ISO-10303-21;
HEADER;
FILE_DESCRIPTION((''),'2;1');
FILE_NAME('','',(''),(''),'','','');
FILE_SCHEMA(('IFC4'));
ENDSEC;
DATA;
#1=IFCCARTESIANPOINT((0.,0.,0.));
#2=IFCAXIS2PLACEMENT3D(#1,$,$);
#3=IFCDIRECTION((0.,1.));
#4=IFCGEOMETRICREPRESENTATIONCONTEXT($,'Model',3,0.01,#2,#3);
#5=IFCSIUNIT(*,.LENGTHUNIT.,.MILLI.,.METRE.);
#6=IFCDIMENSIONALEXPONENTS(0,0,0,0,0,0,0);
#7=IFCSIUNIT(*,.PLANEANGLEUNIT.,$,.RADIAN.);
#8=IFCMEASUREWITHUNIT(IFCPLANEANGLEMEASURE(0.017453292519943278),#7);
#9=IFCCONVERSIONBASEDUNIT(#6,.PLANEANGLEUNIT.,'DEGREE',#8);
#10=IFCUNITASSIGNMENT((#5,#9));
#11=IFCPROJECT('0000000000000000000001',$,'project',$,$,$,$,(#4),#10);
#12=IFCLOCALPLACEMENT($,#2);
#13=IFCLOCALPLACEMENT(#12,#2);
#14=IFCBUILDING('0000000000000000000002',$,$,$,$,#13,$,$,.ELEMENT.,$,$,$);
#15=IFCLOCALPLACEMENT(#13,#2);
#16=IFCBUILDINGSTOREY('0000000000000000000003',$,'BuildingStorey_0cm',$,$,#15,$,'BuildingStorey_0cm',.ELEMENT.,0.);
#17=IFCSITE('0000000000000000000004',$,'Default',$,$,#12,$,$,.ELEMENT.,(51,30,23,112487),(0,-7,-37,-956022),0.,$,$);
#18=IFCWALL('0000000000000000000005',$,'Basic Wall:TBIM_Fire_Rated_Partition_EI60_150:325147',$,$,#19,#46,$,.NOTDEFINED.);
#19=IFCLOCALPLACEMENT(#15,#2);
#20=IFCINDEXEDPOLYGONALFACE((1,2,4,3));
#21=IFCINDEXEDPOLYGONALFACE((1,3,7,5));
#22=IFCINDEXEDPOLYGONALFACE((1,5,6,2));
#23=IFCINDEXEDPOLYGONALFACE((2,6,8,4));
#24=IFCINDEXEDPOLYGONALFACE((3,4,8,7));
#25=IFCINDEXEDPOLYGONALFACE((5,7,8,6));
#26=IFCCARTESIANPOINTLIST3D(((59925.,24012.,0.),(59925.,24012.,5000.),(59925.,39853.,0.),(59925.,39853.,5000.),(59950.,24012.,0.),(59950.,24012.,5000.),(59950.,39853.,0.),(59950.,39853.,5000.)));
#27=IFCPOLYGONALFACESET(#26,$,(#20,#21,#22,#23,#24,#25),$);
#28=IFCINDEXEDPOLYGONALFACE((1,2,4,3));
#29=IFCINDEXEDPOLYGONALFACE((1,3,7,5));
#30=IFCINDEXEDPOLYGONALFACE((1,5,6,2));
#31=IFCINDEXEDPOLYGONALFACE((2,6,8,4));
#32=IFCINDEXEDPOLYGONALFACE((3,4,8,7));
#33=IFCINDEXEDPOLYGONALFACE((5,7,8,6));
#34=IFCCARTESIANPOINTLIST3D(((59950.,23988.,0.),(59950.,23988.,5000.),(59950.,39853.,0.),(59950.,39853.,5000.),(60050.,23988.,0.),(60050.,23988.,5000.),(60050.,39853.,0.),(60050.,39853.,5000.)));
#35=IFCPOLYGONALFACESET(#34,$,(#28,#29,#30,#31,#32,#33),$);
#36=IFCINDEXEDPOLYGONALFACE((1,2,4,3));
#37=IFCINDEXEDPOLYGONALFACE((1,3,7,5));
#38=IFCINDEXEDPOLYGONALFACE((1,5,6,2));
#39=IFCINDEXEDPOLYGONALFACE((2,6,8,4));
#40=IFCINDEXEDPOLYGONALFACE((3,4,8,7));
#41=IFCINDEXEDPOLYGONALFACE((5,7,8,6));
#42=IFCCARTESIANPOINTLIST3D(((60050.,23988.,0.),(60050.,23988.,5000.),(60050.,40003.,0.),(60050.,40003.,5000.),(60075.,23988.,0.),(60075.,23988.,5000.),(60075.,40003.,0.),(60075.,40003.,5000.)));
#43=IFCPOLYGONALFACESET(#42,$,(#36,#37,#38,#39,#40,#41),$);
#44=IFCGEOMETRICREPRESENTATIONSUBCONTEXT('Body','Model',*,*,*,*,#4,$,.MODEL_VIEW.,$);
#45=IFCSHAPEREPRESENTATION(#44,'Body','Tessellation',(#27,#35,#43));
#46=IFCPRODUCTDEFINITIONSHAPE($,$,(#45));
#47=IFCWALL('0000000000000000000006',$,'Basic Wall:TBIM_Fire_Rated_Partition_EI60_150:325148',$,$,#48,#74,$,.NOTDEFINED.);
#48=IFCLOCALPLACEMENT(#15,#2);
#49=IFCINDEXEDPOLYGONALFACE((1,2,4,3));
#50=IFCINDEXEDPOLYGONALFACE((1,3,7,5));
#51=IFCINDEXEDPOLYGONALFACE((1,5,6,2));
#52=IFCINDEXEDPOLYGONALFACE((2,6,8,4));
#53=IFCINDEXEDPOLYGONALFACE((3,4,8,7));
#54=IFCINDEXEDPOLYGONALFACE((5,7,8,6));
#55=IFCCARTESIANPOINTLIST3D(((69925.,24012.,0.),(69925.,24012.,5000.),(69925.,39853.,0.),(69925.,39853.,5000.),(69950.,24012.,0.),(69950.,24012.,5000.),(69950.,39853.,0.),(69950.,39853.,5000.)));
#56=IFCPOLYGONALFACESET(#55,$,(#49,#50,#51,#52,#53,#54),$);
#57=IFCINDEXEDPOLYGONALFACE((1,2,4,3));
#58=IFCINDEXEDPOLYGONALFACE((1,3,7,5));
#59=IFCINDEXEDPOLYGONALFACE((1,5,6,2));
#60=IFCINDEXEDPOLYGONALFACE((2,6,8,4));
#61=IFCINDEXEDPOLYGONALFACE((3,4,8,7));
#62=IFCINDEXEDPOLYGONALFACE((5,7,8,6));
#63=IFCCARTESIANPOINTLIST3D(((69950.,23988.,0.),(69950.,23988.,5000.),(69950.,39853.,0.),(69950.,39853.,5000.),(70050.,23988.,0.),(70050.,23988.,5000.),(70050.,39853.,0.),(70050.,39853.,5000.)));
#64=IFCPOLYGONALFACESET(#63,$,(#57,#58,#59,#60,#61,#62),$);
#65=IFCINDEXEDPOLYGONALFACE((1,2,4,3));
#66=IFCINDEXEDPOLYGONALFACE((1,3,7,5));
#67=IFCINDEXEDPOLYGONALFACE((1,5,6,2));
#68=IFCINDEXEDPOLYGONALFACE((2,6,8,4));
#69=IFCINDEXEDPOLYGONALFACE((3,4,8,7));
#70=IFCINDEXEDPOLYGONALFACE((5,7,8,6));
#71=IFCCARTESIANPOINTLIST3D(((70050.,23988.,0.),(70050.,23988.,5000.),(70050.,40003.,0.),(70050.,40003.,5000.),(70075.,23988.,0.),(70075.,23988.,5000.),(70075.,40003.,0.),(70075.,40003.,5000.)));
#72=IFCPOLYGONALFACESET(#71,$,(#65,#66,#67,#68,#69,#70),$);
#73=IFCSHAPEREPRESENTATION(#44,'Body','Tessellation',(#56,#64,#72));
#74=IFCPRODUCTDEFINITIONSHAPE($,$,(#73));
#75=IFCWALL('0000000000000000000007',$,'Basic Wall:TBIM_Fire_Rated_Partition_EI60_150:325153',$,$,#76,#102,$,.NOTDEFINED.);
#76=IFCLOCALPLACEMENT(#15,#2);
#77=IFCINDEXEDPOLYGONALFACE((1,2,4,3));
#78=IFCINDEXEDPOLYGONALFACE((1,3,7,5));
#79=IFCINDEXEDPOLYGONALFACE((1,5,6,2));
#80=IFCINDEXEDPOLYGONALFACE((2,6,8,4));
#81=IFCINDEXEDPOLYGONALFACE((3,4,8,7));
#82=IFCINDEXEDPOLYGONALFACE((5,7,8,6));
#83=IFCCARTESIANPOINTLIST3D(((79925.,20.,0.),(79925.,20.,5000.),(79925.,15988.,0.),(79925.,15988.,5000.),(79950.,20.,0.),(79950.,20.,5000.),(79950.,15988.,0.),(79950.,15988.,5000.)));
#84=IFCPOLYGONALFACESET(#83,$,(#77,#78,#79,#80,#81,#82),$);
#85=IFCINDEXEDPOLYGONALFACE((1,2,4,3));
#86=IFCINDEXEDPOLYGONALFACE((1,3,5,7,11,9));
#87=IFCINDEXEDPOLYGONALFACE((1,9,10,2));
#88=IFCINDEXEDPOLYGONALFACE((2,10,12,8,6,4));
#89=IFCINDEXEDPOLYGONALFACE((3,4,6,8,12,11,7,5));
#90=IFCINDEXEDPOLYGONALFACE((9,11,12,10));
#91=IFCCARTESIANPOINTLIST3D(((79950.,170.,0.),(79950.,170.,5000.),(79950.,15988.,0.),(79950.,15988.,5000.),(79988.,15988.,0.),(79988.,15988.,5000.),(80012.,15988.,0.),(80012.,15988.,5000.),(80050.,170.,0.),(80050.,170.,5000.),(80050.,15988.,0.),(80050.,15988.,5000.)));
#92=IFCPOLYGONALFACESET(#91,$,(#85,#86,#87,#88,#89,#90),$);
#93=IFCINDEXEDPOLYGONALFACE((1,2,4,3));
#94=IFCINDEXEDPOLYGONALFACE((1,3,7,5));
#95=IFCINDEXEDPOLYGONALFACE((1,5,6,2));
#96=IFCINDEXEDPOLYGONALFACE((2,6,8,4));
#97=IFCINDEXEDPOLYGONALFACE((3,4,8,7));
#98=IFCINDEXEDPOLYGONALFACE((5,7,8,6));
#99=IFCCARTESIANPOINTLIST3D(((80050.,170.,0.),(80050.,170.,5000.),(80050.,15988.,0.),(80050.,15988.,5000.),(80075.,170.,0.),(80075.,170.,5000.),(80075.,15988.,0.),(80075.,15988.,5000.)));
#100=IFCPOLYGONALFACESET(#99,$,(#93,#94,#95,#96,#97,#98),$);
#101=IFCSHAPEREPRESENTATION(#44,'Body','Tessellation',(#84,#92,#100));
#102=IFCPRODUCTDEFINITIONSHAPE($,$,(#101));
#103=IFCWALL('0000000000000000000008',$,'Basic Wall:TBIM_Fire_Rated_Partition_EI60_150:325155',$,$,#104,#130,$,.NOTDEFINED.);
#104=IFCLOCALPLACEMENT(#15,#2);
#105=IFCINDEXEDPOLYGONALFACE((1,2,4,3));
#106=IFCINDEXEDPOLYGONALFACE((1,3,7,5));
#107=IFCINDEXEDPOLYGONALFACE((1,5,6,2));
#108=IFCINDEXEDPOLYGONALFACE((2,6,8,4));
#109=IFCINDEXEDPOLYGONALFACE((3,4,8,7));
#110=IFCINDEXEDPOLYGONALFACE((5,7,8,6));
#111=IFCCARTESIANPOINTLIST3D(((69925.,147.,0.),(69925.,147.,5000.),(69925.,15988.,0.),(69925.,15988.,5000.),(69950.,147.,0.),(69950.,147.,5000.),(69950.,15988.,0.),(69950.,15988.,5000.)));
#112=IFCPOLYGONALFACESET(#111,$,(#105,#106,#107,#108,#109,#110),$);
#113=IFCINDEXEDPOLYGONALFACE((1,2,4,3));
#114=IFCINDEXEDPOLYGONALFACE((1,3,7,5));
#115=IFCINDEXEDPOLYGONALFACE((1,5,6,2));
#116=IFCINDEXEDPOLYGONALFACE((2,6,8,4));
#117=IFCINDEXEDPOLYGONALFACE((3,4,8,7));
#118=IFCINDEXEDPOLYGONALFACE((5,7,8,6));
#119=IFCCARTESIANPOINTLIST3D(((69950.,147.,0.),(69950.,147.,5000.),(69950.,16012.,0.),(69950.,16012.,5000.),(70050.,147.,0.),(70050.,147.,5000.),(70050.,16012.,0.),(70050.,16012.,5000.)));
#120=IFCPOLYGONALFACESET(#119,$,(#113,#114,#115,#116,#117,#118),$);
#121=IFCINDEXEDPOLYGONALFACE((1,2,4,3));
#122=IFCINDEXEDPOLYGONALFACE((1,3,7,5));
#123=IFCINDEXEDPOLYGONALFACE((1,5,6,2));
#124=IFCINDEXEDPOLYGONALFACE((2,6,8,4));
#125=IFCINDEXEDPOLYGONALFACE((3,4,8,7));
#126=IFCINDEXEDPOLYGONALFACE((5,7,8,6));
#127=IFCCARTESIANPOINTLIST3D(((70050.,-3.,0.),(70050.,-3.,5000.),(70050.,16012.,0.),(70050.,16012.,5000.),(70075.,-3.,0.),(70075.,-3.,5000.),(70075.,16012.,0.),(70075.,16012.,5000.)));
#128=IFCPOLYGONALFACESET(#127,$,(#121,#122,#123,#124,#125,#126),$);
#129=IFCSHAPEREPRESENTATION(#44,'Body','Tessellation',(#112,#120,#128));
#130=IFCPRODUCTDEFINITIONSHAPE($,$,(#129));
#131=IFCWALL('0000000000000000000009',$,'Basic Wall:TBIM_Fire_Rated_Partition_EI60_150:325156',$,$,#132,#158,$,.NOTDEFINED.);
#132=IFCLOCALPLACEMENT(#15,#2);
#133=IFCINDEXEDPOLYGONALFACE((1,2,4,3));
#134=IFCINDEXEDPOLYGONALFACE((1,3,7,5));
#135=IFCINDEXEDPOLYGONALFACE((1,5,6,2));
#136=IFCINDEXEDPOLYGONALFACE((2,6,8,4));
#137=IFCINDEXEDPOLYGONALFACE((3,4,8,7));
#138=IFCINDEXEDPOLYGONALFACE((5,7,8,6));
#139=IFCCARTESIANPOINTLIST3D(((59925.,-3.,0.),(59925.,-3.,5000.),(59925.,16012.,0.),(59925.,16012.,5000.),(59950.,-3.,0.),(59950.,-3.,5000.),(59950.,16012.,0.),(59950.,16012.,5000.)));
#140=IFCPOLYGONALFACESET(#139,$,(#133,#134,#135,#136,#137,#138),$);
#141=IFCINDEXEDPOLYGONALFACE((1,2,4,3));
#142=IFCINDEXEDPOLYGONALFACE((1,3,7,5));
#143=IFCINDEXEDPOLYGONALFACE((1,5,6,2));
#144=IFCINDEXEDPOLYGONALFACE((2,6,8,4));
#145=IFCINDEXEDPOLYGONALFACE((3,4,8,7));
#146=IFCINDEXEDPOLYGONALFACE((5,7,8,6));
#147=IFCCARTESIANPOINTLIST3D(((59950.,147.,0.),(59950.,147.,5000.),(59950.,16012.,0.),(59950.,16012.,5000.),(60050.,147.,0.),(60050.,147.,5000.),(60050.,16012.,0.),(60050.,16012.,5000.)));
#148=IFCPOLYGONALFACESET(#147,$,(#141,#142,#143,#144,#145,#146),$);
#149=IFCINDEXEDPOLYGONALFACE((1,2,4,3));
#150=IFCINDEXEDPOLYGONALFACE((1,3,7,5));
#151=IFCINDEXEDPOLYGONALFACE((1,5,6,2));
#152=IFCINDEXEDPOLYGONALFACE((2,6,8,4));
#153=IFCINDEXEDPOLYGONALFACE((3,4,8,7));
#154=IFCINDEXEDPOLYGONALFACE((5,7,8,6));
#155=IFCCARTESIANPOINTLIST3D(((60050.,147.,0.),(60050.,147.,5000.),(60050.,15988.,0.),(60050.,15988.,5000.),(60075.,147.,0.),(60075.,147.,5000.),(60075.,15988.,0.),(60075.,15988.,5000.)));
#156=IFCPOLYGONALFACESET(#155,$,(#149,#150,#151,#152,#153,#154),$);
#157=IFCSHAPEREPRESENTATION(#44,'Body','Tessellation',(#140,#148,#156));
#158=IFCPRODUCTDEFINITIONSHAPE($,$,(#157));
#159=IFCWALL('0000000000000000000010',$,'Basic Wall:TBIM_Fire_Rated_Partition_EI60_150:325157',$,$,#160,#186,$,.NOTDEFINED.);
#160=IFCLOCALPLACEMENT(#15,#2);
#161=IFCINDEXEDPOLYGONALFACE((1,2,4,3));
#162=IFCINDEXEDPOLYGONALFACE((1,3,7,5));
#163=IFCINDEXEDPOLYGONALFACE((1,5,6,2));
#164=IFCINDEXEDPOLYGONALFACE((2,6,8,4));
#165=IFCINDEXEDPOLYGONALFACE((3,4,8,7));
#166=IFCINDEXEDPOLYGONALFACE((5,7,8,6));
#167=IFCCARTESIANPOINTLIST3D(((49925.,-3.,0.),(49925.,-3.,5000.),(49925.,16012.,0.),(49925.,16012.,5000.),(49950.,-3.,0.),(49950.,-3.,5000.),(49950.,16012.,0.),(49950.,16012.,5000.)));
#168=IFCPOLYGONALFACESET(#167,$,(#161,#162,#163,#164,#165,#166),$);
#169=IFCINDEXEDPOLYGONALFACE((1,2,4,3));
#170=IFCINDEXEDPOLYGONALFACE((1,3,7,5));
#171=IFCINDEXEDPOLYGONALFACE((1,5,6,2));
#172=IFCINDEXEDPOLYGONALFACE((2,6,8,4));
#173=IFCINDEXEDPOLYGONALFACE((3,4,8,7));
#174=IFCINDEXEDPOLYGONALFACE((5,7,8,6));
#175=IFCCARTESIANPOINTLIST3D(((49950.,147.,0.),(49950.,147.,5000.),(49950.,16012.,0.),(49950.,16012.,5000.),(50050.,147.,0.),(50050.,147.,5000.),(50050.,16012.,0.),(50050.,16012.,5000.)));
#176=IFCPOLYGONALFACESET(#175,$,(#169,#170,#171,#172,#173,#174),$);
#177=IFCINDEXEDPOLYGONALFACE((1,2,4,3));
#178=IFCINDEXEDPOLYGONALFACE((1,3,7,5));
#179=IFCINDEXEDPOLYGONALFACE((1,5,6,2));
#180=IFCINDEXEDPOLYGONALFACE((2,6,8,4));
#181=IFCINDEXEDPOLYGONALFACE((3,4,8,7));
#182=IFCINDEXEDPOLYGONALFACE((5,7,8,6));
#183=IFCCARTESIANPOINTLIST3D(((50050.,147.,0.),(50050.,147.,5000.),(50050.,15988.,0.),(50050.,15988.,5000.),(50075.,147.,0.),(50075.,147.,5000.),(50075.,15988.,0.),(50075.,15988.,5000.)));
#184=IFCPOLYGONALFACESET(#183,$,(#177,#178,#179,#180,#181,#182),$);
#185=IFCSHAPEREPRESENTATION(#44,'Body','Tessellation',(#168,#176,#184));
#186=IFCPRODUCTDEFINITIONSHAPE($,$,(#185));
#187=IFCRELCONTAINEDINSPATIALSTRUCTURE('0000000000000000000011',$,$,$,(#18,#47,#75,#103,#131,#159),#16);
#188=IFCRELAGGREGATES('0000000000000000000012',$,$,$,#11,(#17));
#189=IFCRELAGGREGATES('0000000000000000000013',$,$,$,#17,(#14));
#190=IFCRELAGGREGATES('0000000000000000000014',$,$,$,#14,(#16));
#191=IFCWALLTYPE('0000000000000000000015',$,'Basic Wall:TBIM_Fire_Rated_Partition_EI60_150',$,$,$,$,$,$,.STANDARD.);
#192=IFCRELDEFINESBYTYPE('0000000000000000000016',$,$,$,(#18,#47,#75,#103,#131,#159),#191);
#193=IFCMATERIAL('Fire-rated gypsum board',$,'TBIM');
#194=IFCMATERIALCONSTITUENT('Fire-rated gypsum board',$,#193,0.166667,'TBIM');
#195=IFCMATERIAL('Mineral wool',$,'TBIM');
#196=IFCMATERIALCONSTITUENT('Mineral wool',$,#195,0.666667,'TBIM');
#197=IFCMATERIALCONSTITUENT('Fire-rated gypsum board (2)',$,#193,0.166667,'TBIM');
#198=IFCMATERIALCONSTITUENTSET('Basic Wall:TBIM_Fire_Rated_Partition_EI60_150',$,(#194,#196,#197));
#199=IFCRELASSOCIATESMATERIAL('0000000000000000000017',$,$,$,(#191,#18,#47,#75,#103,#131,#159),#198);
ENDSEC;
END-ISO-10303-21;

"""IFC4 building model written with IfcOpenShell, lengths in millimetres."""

from ifc_helpers import new_model, entity, si_unit, converted_unit, direction, frame, origin, place, context, subcontext, project, spatial, indexed_curve, outline, extrude, material, constituent, constituent_set, type_object, element, save


model = new_model("IFC4")

# Units and contexts
model_context = context("Model", 3, precision=0.01, world=origin(), true_north=direction((0.0, 1.0)))
body_context = subcontext(model_context, "Body", "Model", "MODEL_VIEW")
ifc_project = project(units=[si_unit("LENGTHUNIT", "METRE", prefix="MILLI"), converted_unit("PLANEANGLEUNIT", "DEGREE", entity("IfcPlaneAngleMeasure", 0.017453292519943278), si_unit("PLANEANGLEUNIT", "RADIAN"), dimensions=[0, 0, 0, 0, 0, 0, 0])], contexts=[model_context])

# Site, building, storey
site_placement = place(None, origin())
site = spatial("IfcSite", under=ifc_project, at=site_placement, Name="Default", CompositionType="ELEMENT", RefLatitude=(51, 30, 23, 112487), RefLongitude=(0, -7, -37, -956022), RefElevation=0.0)
building_placement = place(site_placement, origin())
building = spatial("IfcBuilding", under=site, at=building_placement, CompositionType="ELEMENT")
storey_placement = place(building_placement, origin())
storey = spatial("IfcBuildingStorey", under=building, at=storey_placement, Name="BuildingStorey_0cm", LongName="BuildingStorey_0cm", CompositionType="ELEMENT", Elevation=0.0)

# Shared definitions
ifc_material_1 = material(Name="Mineral wool", Category="TBIM")

# Walls
ifc_material_2 = material(Name="Fire-rated gypsum board", Category="TBIM")
ifc_constituent_1 = constituent(ifc_material_2, Name="Fire-rated gypsum board", Category="TBIM", fraction=0.166667)
ifc_constituent_2 = constituent(ifc_material_1, Name="Mineral wool", Category="TBIM", fraction=0.666667)
ifc_constituent_3 = constituent(ifc_material_2, Name="Fire-rated gypsum board (2)", Category="TBIM", fraction=0.166667)
ifc_constituent_set_1 = constituent_set(constituents=[ifc_constituent_1, ifc_constituent_2, ifc_constituent_3], Name="Basic Wall:TBIM_Fire_Rated_Partition_EI60_150")
wall_type_1 = type_object("IfcWallType", Name="Basic Wall:TBIM_Fire_Rated_Partition_EI60_150", PredefinedType="STANDARD", material=ifc_constituent_set_1)
wall_1_placement = place(storey_placement, frame((60000.0, 24012.0, 0.0), z_axis=(0.0, 0.0, 1.0), x_axis=(0.0, 1.0, 0.0)))
element("IfcWall", 1, at=wall_1_placement, inside=storey, type_object=wall_type_1, material=ifc_constituent_set_1, Name="Basic Wall:TBIM_Fire_Rated_Partition_EI60_150:325147", PredefinedType="NOTDEFINED", context=body_context, shape_type="SweptSolid", body=[
    extrude(outline(indexed_curve([(-12.5, -7920.5), (12.5, -7920.5), (12.5, 7920.5), (-12.5, 7920.5), (-12.5, -7920.5)], self_intersect=False)), frame((7920.5, 62.5, 0.0), z_axis=(0.0, 0.0, 1.0), x_axis=(0.0, -1.0, 0.0)), (0.0, 0.0, 1.0), 5000.0),
    extrude(outline(indexed_curve([(-7932.5, -50.0), (7932.5, -50.0), (7932.5, 50.0), (-7932.5, 50.0), (-7932.5, -50.0)], self_intersect=False)), frame((7908.5, 0.0, 0.0)), (0.0, 0.0, 1.0), 5000.0),
    extrude(outline(indexed_curve([(-12.5, -8007.5), (12.5, -8007.5), (12.5, 8007.5), (-12.5, 8007.5), (-12.5, -8007.5)], self_intersect=False)), frame((7983.5, -62.5, 0.0), z_axis=(0.0, 0.0, 1.0), x_axis=(0.0, 1.0, 0.0)), (0.0, 0.0, 1.0), 5000.0),
])
wall_2_placement = place(storey_placement, frame((70000.0, 24012.0, 0.0), z_axis=(0.0, 0.0, 1.0), x_axis=(0.0, 1.0, 0.0)))
element("IfcWall", 2, at=wall_2_placement, inside=storey, type_object=wall_type_1, material=ifc_constituent_set_1, Name="Basic Wall:TBIM_Fire_Rated_Partition_EI60_150:325148", PredefinedType="NOTDEFINED", context=body_context, shape_type="SweptSolid", body=[
    extrude(outline(indexed_curve([(-12.5, -7920.5), (12.5, -7920.5), (12.5, 7920.5), (-12.5, 7920.5), (-12.5, -7920.5)], self_intersect=False)), frame((7920.5, 62.5, 0.0), z_axis=(0.0, 0.0, 1.0), x_axis=(0.0, -1.0, 0.0)), (0.0, 0.0, 1.0), 5000.0),
    extrude(outline(indexed_curve([(-7932.5, -50.0), (7932.5, -50.0), (7932.5, 50.0), (-7932.5, 50.0), (-7932.5, -50.0)], self_intersect=False)), frame((7908.5, 0.0, 0.0)), (0.0, 0.0, 1.0), 5000.0),
    extrude(outline(indexed_curve([(-12.5, -8007.5), (12.5, -8007.5), (12.5, 8007.5), (-12.5, 8007.5), (-12.5, -8007.5)], self_intersect=False)), frame((7983.5, -62.5, 0.0), z_axis=(0.0, 0.0, 1.0), x_axis=(0.0, 1.0, 0.0)), (0.0, 0.0, 1.0), 5000.0),
])
wall_3_placement = place(storey_placement, frame((80000.0, 170.0, 0.0), z_axis=(0.0, 0.0, 1.0), x_axis=(0.0, 1.0, 0.0)))
element("IfcWall", 3, at=wall_3_placement, inside=storey, type_object=wall_type_1, material=ifc_constituent_set_1, Name="Basic Wall:TBIM_Fire_Rated_Partition_EI60_150:325153", PredefinedType="NOTDEFINED", context=body_context, shape_type="SweptSolid", body=[
    extrude(outline(indexed_curve([(-12.5, -7984.0), (12.5, -7984.0), (12.5, 7984.0), (-12.5, 7984.0), (-12.5, -7984.0)], self_intersect=False)), frame((7834.0, 62.5, 0.0), z_axis=(0.0, 0.0, 1.0), x_axis=(0.0, -1.0, 0.0)), (0.0, 0.0, 1.0), 5000.0),
    extrude(outline(indexed_curve([(12.0, -5272.7), (50.0, -5272.7), (50.0, 10545.3), (-50.0, 10545.3), (-50.0, -5272.7), (-12.0, -5272.7), (12.0, -5272.7)], self_intersect=False)), frame((10545.3, 0.0, 0.0), z_axis=(0.0, 0.0, 1.0), x_axis=(0.0, 1.0, 0.0)), (0.0, 0.0, 1.0), 5000.0),
    extrude(outline(indexed_curve([(-12.5, -7909.0), (12.5, -7909.0), (12.5, 7909.0), (-12.5, 7909.0), (-12.5, -7909.0)], self_intersect=False)), frame((7909.0, -62.5, 0.0), z_axis=(0.0, 0.0, 1.0), x_axis=(0.0, 1.0, 0.0)), (0.0, 0.0, 1.0), 5000.0),
])
wall_4_placement = place(storey_placement, frame((70000.0, 147.0, 0.0), z_axis=(0.0, 0.0, 1.0), x_axis=(0.0, 1.0, 0.0)))
element("IfcWall", 4, at=wall_4_placement, inside=storey, type_object=wall_type_1, material=ifc_constituent_set_1, Name="Basic Wall:TBIM_Fire_Rated_Partition_EI60_150:325155", PredefinedType="NOTDEFINED", context=body_context, shape_type="SweptSolid", body=[
    extrude(outline(indexed_curve([(-12.5, -7920.5), (12.5, -7920.5), (12.5, 7920.5), (-12.5, 7920.5), (-12.5, -7920.5)], self_intersect=False)), frame((7920.5, 62.5, 0.0), z_axis=(0.0, 0.0, 1.0), x_axis=(0.0, -1.0, 0.0)), (0.0, 0.0, 1.0), 5000.0),
    extrude(outline(indexed_curve([(-7932.5, -50.0), (7932.5, -50.0), (7932.5, 50.0), (-7932.5, 50.0), (-7932.5, -50.0)], self_intersect=False)), frame((7932.5, 0.0, 0.0)), (0.0, 0.0, 1.0), 5000.0),
    extrude(outline(indexed_curve([(-12.5, -8007.5), (12.5, -8007.5), (12.5, 8007.5), (-12.5, 8007.5), (-12.5, -8007.5)], self_intersect=False)), frame((7857.5, -62.5, 0.0), z_axis=(0.0, 0.0, 1.0), x_axis=(0.0, 1.0, 0.0)), (0.0, 0.0, 1.0), 5000.0),
])
wall_5_placement = place(storey_placement, frame((60000.0, 147.0, 0.0), z_axis=(0.0, 0.0, 1.0), x_axis=(0.0, 1.0, 0.0)))
element("IfcWall", 5, at=wall_5_placement, inside=storey, type_object=wall_type_1, material=ifc_constituent_set_1, Name="Basic Wall:TBIM_Fire_Rated_Partition_EI60_150:325156", PredefinedType="NOTDEFINED", context=body_context, shape_type="SweptSolid", body=[
    extrude(outline(indexed_curve([(-12.5, -8007.5), (12.5, -8007.5), (12.5, 8007.5), (-12.5, 8007.5), (-12.5, -8007.5)], self_intersect=False)), frame((7857.5, 62.5, 0.0), z_axis=(0.0, 0.0, 1.0), x_axis=(0.0, -1.0, 0.0)), (0.0, 0.0, 1.0), 5000.0),
    extrude(outline(indexed_curve([(-7932.5, -50.0), (7932.5, -50.0), (7932.5, 50.0), (-7932.5, 50.0), (-7932.5, -50.0)], self_intersect=False)), frame((7932.5, 0.0, 0.0)), (0.0, 0.0, 1.0), 5000.0),
    extrude(outline(indexed_curve([(-12.5, -7920.5), (12.5, -7920.5), (12.5, 7920.5), (-12.5, 7920.5), (-12.5, -7920.5)], self_intersect=False)), frame((7920.5, -62.5, 0.0), z_axis=(0.0, 0.0, 1.0), x_axis=(0.0, 1.0, 0.0)), (0.0, 0.0, 1.0), 5000.0),
])
wall_6_placement = place(storey_placement, frame((50000.0, 147.0, 0.0), z_axis=(0.0, 0.0, 1.0), x_axis=(0.0, 1.0, 0.0)))
element("IfcWall", 6, at=wall_6_placement, inside=storey, type_object=wall_type_1, material=ifc_constituent_set_1, Name="Basic Wall:TBIM_Fire_Rated_Partition_EI60_150:325157", PredefinedType="NOTDEFINED", context=body_context, shape_type="SweptSolid", body=[
    extrude(outline(indexed_curve([(-12.5, -8007.5), (12.5, -8007.5), (12.5, 8007.5), (-12.5, 8007.5), (-12.5, -8007.5)], self_intersect=False)), frame((7857.5, 62.5, 0.0), z_axis=(0.0, 0.0, 1.0), x_axis=(0.0, -1.0, 0.0)), (0.0, 0.0, 1.0), 5000.0),
    extrude(outline(indexed_curve([(-7932.5, -50.0), (7932.5, -50.0), (7932.5, 50.0), (-7932.5, 50.0), (-7932.5, -50.0)], self_intersect=False)), frame((7932.5, 0.0, 0.0)), (0.0, 0.0, 1.0), 5000.0),
    extrude(outline(indexed_curve([(-12.5, -7920.5), (12.5, -7920.5), (12.5, 7920.5), (-12.5, 7920.5), (-12.5, -7920.5)], self_intersect=False)), frame((7920.5, -62.5, 0.0), z_axis=(0.0, 0.0, 1.0), x_axis=(0.0, 1.0, 0.0)), (0.0, 0.0, 1.0), 5000.0),
])

save(model, "model.ifc")
